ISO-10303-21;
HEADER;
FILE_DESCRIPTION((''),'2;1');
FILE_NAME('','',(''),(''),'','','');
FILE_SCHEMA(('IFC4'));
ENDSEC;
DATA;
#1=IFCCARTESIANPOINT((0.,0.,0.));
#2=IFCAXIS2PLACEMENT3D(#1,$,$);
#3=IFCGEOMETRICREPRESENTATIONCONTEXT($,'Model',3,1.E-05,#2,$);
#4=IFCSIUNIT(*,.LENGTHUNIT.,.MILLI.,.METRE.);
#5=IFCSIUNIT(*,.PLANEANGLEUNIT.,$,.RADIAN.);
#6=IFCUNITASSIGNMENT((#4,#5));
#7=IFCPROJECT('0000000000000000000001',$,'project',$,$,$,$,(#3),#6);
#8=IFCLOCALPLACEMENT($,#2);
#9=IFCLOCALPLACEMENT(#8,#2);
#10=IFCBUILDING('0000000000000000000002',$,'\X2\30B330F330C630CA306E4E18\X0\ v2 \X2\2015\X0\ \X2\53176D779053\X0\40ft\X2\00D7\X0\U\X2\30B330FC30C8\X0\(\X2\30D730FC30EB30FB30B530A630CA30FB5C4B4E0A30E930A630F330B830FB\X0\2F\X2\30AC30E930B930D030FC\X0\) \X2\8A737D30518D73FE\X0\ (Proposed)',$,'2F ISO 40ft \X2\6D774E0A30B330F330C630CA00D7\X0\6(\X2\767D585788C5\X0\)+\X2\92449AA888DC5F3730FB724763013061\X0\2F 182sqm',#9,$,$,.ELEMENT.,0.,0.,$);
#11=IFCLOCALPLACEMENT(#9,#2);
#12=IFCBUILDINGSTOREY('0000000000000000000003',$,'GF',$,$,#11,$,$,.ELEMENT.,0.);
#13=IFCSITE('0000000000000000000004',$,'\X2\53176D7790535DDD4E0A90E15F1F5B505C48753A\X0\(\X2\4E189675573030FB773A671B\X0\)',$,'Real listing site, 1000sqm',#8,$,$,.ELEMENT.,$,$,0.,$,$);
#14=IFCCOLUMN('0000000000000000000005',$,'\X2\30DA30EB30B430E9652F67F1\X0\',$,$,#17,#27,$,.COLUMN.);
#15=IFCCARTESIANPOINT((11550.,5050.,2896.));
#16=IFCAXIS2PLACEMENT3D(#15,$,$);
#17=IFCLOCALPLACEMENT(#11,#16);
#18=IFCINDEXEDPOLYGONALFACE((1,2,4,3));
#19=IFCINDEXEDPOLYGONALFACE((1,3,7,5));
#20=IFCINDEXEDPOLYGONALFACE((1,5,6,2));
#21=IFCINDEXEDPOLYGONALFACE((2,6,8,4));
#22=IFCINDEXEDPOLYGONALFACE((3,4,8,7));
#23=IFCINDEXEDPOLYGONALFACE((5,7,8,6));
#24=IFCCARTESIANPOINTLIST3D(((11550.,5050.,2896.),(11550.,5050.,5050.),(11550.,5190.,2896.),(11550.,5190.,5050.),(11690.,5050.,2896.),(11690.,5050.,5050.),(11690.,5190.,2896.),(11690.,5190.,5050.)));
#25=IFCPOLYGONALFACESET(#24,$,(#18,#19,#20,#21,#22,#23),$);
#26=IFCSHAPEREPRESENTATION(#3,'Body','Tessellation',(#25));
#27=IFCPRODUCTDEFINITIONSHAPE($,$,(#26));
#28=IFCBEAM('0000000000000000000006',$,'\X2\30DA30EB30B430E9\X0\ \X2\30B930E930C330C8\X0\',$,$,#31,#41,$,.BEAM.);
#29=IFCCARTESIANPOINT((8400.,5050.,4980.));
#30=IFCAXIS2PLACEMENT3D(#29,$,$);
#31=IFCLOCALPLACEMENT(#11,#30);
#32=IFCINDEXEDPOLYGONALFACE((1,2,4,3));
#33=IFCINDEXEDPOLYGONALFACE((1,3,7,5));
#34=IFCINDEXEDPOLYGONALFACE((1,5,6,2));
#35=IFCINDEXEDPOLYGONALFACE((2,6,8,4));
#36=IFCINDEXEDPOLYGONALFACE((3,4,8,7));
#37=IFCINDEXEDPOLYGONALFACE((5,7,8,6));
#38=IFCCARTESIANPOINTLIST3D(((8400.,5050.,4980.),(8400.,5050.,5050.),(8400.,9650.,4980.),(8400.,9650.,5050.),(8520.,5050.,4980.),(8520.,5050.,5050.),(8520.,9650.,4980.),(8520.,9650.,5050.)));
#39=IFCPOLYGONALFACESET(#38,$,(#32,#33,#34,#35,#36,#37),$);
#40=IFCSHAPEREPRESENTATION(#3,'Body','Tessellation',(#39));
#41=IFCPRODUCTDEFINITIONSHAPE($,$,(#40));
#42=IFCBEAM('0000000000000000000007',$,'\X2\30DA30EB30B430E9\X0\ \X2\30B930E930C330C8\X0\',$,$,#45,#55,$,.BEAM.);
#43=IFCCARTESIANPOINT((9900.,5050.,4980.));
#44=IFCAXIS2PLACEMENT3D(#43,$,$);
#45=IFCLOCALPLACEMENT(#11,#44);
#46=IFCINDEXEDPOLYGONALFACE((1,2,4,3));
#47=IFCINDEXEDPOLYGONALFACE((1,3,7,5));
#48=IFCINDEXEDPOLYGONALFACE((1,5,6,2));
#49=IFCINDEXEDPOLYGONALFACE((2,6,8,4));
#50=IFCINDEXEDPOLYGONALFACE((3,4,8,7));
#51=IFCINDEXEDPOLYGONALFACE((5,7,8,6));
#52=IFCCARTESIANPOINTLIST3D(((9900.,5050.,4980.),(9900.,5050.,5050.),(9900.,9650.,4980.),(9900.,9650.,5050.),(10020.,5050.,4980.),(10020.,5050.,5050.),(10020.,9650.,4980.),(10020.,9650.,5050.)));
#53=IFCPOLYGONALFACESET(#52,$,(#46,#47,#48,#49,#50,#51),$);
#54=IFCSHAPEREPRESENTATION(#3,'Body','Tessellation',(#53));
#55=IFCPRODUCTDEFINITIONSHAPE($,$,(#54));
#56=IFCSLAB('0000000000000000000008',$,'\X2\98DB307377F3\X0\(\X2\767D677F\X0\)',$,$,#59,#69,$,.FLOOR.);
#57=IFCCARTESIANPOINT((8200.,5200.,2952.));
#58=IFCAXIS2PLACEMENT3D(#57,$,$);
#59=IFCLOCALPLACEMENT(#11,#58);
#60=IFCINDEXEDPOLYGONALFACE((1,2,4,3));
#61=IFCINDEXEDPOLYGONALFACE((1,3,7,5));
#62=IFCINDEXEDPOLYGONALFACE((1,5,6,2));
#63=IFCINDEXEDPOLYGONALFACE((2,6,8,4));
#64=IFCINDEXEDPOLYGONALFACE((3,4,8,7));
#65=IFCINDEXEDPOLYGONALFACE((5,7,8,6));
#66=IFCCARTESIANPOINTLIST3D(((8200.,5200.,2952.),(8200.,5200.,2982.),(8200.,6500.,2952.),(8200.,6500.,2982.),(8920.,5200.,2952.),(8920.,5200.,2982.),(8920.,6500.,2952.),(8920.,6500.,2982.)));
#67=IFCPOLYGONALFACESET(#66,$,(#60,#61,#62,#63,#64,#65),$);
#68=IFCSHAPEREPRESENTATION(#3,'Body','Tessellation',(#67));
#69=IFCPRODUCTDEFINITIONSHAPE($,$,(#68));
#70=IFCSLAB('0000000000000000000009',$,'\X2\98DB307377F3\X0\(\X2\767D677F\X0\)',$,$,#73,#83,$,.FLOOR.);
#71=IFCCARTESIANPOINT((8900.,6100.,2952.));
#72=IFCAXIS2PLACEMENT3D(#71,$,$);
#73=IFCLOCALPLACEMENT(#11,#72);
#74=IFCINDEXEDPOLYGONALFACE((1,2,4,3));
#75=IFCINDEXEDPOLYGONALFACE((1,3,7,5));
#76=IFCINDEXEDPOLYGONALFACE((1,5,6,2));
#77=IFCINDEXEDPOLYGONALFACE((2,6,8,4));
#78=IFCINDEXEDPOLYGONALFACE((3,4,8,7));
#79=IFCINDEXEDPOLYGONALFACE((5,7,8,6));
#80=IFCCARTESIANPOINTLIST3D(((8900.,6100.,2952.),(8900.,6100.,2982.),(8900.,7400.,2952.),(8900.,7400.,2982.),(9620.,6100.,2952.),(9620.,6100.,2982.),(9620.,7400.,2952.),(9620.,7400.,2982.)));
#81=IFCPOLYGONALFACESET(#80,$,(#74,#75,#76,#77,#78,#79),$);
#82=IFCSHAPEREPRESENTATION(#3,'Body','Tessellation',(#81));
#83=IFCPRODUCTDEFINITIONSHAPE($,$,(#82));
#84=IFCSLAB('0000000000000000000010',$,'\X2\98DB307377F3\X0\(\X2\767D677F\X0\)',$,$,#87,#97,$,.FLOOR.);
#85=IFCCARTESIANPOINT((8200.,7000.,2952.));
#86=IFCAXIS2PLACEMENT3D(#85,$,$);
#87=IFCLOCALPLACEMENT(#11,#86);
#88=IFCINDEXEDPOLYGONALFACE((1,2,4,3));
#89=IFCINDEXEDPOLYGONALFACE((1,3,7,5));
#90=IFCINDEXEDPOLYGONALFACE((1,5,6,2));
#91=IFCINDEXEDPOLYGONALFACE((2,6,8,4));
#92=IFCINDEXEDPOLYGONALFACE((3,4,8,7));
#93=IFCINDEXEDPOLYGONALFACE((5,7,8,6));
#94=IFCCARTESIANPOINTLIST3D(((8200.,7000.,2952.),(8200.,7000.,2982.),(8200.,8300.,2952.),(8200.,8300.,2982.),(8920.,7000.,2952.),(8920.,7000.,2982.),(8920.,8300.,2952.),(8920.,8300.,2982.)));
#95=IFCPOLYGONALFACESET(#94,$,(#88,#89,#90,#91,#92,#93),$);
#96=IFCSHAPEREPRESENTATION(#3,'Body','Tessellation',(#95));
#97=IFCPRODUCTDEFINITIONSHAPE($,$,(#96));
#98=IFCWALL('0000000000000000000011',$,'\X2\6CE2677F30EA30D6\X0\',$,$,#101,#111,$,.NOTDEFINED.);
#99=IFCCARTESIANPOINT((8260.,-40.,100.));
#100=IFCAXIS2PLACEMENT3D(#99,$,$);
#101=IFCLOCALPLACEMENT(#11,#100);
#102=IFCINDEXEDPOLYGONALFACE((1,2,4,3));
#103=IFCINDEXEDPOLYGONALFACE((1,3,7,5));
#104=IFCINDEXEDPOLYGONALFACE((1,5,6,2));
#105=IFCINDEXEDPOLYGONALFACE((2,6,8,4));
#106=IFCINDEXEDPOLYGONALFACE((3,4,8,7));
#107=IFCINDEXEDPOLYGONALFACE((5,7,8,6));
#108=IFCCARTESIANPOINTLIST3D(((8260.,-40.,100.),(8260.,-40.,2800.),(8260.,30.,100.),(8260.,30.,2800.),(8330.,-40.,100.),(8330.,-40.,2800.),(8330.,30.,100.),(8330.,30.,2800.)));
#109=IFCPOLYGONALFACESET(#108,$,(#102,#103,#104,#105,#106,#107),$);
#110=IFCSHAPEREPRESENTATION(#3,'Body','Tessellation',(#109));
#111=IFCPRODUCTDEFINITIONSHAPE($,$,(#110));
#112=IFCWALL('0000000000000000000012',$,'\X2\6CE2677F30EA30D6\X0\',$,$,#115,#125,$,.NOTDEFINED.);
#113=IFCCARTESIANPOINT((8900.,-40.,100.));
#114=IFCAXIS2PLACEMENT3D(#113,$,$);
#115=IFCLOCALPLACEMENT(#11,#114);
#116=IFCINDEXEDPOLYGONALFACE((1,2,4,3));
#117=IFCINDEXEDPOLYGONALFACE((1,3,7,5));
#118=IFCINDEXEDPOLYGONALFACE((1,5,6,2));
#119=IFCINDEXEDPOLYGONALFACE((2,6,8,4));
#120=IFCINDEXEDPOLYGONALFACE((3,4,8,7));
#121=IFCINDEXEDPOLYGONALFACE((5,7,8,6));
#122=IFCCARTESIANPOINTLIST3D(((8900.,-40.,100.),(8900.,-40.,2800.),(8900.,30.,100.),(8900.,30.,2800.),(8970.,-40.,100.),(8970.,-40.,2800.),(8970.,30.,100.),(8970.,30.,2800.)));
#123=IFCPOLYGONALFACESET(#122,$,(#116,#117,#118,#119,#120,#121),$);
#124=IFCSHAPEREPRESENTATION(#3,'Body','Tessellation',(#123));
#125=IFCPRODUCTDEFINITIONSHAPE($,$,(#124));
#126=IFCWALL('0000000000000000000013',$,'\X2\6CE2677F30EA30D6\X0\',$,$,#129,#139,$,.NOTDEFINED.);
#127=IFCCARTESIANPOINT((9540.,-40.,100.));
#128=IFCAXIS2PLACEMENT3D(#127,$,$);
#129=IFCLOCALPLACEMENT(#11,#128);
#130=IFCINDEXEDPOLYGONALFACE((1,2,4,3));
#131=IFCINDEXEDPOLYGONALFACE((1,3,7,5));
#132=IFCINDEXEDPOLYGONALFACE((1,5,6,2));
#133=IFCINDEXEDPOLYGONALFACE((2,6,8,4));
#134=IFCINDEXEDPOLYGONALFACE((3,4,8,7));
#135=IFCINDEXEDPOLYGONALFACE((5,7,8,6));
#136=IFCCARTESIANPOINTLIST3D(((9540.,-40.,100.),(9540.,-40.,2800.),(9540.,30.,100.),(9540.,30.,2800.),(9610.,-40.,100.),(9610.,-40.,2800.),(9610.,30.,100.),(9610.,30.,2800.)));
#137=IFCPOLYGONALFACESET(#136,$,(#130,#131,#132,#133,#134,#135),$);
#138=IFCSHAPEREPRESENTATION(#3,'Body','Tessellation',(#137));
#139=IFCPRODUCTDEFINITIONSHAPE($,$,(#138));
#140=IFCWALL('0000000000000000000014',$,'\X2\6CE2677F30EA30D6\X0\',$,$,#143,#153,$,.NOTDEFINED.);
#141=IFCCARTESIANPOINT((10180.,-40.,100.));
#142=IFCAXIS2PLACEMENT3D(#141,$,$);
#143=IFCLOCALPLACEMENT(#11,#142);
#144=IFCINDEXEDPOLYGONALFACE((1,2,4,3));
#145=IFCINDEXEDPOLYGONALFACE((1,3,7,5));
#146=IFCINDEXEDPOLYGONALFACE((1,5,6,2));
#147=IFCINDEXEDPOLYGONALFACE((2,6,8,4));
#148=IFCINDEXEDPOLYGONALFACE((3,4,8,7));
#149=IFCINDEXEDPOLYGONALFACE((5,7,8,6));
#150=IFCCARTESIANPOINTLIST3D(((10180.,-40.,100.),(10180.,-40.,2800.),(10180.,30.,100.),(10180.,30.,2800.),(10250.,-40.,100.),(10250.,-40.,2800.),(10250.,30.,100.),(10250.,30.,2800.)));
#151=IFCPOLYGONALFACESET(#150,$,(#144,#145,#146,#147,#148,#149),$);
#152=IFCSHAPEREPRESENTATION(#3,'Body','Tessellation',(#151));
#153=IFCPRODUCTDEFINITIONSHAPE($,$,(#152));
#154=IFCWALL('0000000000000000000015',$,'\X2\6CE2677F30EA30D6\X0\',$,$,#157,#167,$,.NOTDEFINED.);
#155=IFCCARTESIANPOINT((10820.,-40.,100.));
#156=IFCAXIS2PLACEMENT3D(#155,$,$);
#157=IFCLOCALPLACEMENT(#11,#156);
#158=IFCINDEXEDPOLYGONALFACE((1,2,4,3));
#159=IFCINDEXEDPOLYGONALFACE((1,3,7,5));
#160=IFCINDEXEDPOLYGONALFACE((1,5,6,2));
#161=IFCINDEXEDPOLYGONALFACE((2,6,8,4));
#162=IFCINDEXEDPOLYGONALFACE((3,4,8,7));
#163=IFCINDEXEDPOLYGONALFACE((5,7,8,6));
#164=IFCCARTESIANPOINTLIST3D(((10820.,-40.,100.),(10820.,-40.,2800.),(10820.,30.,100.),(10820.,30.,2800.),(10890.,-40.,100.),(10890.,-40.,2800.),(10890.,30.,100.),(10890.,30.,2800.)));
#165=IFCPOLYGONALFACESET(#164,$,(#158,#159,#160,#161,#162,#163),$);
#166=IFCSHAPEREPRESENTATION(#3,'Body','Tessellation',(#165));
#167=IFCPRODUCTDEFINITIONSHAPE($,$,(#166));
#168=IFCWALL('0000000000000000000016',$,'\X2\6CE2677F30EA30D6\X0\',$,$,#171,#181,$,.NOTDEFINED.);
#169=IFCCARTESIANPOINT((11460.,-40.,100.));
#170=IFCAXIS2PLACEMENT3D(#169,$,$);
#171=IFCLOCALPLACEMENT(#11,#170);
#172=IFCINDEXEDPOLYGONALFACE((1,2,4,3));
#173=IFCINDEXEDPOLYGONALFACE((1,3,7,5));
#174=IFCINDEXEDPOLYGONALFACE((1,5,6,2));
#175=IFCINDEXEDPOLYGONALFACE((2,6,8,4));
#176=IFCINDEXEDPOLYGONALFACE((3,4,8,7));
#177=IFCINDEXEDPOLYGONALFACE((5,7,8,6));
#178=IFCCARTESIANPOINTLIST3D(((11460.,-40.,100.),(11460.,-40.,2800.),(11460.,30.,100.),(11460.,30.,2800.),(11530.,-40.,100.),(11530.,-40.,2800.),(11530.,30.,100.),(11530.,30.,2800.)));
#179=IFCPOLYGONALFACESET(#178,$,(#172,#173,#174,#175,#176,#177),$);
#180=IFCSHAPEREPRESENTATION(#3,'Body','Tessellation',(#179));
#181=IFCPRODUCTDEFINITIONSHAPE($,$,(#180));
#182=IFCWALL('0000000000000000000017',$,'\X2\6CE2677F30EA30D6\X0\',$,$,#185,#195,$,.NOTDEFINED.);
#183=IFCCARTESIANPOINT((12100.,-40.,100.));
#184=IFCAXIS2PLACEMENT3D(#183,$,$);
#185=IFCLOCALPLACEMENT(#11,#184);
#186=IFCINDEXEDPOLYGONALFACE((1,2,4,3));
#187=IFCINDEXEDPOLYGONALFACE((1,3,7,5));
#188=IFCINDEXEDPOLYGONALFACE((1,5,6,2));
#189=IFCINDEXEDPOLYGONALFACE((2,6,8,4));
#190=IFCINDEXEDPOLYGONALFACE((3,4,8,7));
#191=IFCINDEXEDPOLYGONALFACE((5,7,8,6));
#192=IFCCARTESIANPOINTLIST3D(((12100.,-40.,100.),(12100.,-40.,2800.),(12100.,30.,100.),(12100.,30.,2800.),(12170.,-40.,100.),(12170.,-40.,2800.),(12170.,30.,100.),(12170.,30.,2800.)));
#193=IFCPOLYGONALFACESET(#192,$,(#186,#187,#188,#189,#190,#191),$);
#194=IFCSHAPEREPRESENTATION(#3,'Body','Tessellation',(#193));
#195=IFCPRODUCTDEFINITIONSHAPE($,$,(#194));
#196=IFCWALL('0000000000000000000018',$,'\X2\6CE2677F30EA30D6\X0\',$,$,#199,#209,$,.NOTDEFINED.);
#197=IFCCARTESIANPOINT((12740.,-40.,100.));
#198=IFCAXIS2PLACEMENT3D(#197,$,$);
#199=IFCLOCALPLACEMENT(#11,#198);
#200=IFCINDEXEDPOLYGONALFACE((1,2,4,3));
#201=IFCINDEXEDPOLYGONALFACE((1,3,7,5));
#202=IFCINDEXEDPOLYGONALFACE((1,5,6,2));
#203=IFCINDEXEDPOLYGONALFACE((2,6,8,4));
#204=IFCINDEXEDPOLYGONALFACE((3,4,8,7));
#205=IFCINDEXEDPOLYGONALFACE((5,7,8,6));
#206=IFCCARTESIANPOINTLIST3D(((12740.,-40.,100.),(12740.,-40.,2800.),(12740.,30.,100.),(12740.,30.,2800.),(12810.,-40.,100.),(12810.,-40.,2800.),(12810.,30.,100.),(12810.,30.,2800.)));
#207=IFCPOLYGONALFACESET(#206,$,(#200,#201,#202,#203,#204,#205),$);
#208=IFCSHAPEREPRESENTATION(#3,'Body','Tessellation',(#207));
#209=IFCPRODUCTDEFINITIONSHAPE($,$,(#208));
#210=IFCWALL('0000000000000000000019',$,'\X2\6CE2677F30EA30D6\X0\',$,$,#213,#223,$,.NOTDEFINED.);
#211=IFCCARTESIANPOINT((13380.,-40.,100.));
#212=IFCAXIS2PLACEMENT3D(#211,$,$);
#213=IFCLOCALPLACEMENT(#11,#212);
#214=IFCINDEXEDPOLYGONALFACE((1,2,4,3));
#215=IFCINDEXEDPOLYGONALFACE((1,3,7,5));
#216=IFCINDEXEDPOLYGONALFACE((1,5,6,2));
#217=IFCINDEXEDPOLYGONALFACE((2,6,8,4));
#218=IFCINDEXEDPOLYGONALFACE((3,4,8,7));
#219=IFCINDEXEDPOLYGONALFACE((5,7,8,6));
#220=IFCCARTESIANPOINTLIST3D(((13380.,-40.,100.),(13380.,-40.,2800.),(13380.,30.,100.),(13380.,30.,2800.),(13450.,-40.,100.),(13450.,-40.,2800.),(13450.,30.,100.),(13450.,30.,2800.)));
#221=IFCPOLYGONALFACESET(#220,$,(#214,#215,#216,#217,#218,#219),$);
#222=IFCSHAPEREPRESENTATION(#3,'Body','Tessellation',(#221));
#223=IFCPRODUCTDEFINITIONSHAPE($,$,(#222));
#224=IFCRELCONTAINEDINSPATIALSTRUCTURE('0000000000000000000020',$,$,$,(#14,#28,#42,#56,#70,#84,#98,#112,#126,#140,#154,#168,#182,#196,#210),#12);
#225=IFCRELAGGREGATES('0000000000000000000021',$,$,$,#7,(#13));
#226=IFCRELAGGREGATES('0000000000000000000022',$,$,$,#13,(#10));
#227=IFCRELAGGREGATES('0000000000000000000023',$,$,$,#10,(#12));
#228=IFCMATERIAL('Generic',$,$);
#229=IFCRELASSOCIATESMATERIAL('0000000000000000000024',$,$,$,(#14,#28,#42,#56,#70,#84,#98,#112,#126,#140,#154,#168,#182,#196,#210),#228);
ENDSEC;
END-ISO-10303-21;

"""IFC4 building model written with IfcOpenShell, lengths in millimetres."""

from ifc_helpers import new_model, si_unit, frame, frame_2d, origin, place, context, project, spatial, rectangle, extrude, material, element, save


model = new_model("IFC4")

# Units and contexts
model_context = context("Model", 3, precision=1e-05, world=origin())
ifc_project = project(units=[si_unit("LENGTHUNIT", "METRE", prefix="MILLI"), si_unit("PLANEANGLEUNIT", "RADIAN")], contexts=[model_context])

# Site, building, storey
site_placement = place(None, origin())
site = spatial("IfcSite", under=ifc_project, at=site_placement, Name="北海道川上郡弟子屈町(丘陵地・眺望)", ObjectType="Real listing site, 1000sqm", CompositionType="ELEMENT", RefElevation=0.0)
building_placement = place(site_placement, origin())
building = spatial("IfcBuilding", under=site, at=building_placement, Name="コンテナの丘 v2 ― 北海道40ft×Uコート(プール・サウナ・屋上ラウンジ・2Fガラスバー) 詳細再現 (Proposed)", ObjectType="2F ISO 40ft 海上コンテナ×6(白塗装)+鉄骨補強・片持ち2F 182sqm", CompositionType="ELEMENT", ElevationOfRefHeight=0.0, ElevationOfTerrain=0.0)
storey_placement = place(building_placement, origin())
storey = spatial("IfcBuildingStorey", under=building, at=storey_placement, Name="GF", CompositionType="ELEMENT", Elevation=0.0)

# Column
ifc_material = material(Name="Generic")
column_placement = place(storey_placement, frame((11550.0, 5050.0, 2896.0)))
element("IfcColumn", 1, at=column_placement, inside=storey, material=ifc_material, Name="ペルゴラ支柱", PredefinedType="COLUMN", context=model_context, shape_type="SweptSolid", body=[
    extrude(rectangle(XDim=140.0, YDim=140.0, at=frame_2d((70.0, 70.0))), frame((11550.0, 5050.0, 2896.0)), (0.0, 0.0, 1.0), 2154.0),
])

# Beams
beam_1_placement = place(storey_placement, frame((8400.0, 5050.0, 4980.0)))
element("IfcBeam", 2, at=beam_1_placement, inside=storey, material=ifc_material, Name="ペルゴラ スラット", PredefinedType="BEAM", context=model_context, shape_type="SweptSolid", body=[
    extrude(rectangle(XDim=120.0, YDim=4600.0, at=frame_2d((60.0, 2300.0))), frame((8400.0, 5050.0, 4980.0)), (0.0, 0.0, 1.0), 70.0),
])
beam_2_placement = place(storey_placement, frame((9900.0, 5050.0, 4980.0)))
element("IfcBeam", 3, at=beam_2_placement, inside=storey, material=ifc_material, Name="ペルゴラ スラット", PredefinedType="BEAM", context=model_context, shape_type="SweptSolid", body=[
    extrude(rectangle(XDim=120.0, YDim=4600.0, at=frame_2d((60.0, 2300.0))), frame((9900.0, 5050.0, 4980.0)), (0.0, 0.0, 1.0), 70.0),
])

# Slabs
slab_1_placement = place(storey_placement, frame((8200.0, 5200.0, 2952.0)))
element("IfcSlab", 4, at=slab_1_placement, inside=storey, material=ifc_material, Name="飛び石(白板)", PredefinedType="FLOOR", context=model_context, shape_type="SweptSolid", body=[
    extrude(rectangle(XDim=720.0, YDim=1300.0, at=frame_2d((360.0, 650.0))), frame((8200.0, 5200.0, 2952.0)), (0.0, 0.0, 1.0), 30.0),
])
slab_2_placement = place(storey_placement, frame((8900.0, 6100.0, 2952.0)))
element("IfcSlab", 5, at=slab_2_placement, inside=storey, material=ifc_material, Name="飛び石(白板)", PredefinedType="FLOOR", context=model_context, shape_type="SweptSolid", body=[
    extrude(rectangle(XDim=720.0, YDim=1300.0, at=frame_2d((360.0, 650.0))), frame((8900.0, 6100.0, 2952.0)), (0.0, 0.0, 1.0), 30.0),
])
slab_3_placement = place(storey_placement, frame((8200.0, 7000.0, 2952.0)))
element("IfcSlab", 6, at=slab_3_placement, inside=storey, material=ifc_material, Name="飛び石(白板)", PredefinedType="FLOOR", context=model_context, shape_type="SweptSolid", body=[
    extrude(rectangle(XDim=720.0, YDim=1300.0, at=frame_2d((360.0, 650.0))), frame((8200.0, 7000.0, 2952.0)), (0.0, 0.0, 1.0), 30.0),
])

# Walls
wall_1_placement = place(storey_placement, frame((8260.0, -40.0, 100.0)))
element("IfcWall", 7, at=wall_1_placement, inside=storey, material=ifc_material, Name="波板リブ", PredefinedType="NOTDEFINED", context=model_context, shape_type="SweptSolid", body=[
    extrude(rectangle(XDim=70.0, YDim=70.0, at=frame_2d((35.0, 35.0))), frame((8260.0, -40.0, 100.0)), (0.0, 0.0, 1.0), 2700.0),
])
wall_2_placement = place(storey_placement, frame((8900.0, -40.0, 100.0)))
element("IfcWall", 8, at=wall_2_placement, inside=storey, material=ifc_material, Name="波板リブ", PredefinedType="NOTDEFINED", context=model_context, shape_type="SweptSolid", body=[
    extrude(rectangle(XDim=70.0, YDim=70.0, at=frame_2d((35.0, 35.0))), frame((8900.0, -40.0, 100.0)), (0.0, 0.0, 1.0), 2700.0),
])
wall_3_placement = place(storey_placement, frame((9540.0, -40.0, 100.0)))
element("IfcWall", 9, at=wall_3_placement, inside=storey, material=ifc_material, Name="波板リブ", PredefinedType="NOTDEFINED", context=model_context, shape_type="SweptSolid", body=[
    extrude(rectangle(XDim=70.0, YDim=70.0, at=frame_2d((35.0, 35.0))), frame((9540.0, -40.0, 100.0)), (0.0, 0.0, 1.0), 2700.0),
])
wall_4_placement = place(storey_placement, frame((10180.0, -40.0, 100.0)))
element("IfcWall", 10, at=wall_4_placement, inside=storey, material=ifc_material, Name="波板リブ", PredefinedType="NOTDEFINED", context=model_context, shape_type="SweptSolid", body=[
    extrude(rectangle(XDim=70.0, YDim=70.0, at=frame_2d((35.0, 35.0))), frame((10180.0, -40.0, 100.0)), (0.0, 0.0, 1.0), 2700.0),
])
wall_5_placement = place(storey_placement, frame((10820.0, -40.0, 100.0)))
element("IfcWall", 11, at=wall_5_placement, inside=storey, material=ifc_material, Name="波板リブ", PredefinedType="NOTDEFINED", context=model_context, shape_type="SweptSolid", body=[
    extrude(rectangle(XDim=70.0, YDim=70.0, at=frame_2d((35.0, 35.0))), frame((10820.0, -40.0, 100.0)), (0.0, 0.0, 1.0), 2700.0),
])
wall_6_placement = place(storey_placement, frame((11460.0, -40.0, 100.0)))
element("IfcWall", 12, at=wall_6_placement, inside=storey, material=ifc_material, Name="波板リブ", PredefinedType="NOTDEFINED", context=model_context, shape_type="SweptSolid", body=[
    extrude(rectangle(XDim=70.0, YDim=70.0, at=frame_2d((35.0, 35.0))), frame((11460.0, -40.0, 100.0)), (0.0, 0.0, 1.0), 2700.0),
])
wall_7_placement = place(storey_placement, frame((12100.0, -40.0, 100.0)))
element("IfcWall", 13, at=wall_7_placement, inside=storey, material=ifc_material, Name="波板リブ", PredefinedType="NOTDEFINED", context=model_context, shape_type="SweptSolid", body=[
    extrude(rectangle(XDim=70.0, YDim=70.0, at=frame_2d((35.0, 35.0))), frame((12100.0, -40.0, 100.0)), (0.0, 0.0, 1.0), 2700.0),
])
wall_8_placement = place(storey_placement, frame((12740.0, -40.0, 100.0)))
element("IfcWall", 14, at=wall_8_placement, inside=storey, material=ifc_material, Name="波板リブ", PredefinedType="NOTDEFINED", context=model_context, shape_type="SweptSolid", body=[
    extrude(rectangle(XDim=70.0, YDim=70.0, at=frame_2d((35.0, 35.0))), frame((12740.0, -40.0, 100.0)), (0.0, 0.0, 1.0), 2700.0),
])
wall_9_placement = place(storey_placement, frame((13380.0, -40.0, 100.0)))
element("IfcWall", 15, at=wall_9_placement, inside=storey, material=ifc_material, Name="波板リブ", PredefinedType="NOTDEFINED", context=model_context, shape_type="SweptSolid", body=[
    extrude(rectangle(XDim=70.0, YDim=70.0, at=frame_2d((35.0, 35.0))), frame((13380.0, -40.0, 100.0)), (0.0, 0.0, 1.0), 2700.0),
])

save(model, "model.ifc")
